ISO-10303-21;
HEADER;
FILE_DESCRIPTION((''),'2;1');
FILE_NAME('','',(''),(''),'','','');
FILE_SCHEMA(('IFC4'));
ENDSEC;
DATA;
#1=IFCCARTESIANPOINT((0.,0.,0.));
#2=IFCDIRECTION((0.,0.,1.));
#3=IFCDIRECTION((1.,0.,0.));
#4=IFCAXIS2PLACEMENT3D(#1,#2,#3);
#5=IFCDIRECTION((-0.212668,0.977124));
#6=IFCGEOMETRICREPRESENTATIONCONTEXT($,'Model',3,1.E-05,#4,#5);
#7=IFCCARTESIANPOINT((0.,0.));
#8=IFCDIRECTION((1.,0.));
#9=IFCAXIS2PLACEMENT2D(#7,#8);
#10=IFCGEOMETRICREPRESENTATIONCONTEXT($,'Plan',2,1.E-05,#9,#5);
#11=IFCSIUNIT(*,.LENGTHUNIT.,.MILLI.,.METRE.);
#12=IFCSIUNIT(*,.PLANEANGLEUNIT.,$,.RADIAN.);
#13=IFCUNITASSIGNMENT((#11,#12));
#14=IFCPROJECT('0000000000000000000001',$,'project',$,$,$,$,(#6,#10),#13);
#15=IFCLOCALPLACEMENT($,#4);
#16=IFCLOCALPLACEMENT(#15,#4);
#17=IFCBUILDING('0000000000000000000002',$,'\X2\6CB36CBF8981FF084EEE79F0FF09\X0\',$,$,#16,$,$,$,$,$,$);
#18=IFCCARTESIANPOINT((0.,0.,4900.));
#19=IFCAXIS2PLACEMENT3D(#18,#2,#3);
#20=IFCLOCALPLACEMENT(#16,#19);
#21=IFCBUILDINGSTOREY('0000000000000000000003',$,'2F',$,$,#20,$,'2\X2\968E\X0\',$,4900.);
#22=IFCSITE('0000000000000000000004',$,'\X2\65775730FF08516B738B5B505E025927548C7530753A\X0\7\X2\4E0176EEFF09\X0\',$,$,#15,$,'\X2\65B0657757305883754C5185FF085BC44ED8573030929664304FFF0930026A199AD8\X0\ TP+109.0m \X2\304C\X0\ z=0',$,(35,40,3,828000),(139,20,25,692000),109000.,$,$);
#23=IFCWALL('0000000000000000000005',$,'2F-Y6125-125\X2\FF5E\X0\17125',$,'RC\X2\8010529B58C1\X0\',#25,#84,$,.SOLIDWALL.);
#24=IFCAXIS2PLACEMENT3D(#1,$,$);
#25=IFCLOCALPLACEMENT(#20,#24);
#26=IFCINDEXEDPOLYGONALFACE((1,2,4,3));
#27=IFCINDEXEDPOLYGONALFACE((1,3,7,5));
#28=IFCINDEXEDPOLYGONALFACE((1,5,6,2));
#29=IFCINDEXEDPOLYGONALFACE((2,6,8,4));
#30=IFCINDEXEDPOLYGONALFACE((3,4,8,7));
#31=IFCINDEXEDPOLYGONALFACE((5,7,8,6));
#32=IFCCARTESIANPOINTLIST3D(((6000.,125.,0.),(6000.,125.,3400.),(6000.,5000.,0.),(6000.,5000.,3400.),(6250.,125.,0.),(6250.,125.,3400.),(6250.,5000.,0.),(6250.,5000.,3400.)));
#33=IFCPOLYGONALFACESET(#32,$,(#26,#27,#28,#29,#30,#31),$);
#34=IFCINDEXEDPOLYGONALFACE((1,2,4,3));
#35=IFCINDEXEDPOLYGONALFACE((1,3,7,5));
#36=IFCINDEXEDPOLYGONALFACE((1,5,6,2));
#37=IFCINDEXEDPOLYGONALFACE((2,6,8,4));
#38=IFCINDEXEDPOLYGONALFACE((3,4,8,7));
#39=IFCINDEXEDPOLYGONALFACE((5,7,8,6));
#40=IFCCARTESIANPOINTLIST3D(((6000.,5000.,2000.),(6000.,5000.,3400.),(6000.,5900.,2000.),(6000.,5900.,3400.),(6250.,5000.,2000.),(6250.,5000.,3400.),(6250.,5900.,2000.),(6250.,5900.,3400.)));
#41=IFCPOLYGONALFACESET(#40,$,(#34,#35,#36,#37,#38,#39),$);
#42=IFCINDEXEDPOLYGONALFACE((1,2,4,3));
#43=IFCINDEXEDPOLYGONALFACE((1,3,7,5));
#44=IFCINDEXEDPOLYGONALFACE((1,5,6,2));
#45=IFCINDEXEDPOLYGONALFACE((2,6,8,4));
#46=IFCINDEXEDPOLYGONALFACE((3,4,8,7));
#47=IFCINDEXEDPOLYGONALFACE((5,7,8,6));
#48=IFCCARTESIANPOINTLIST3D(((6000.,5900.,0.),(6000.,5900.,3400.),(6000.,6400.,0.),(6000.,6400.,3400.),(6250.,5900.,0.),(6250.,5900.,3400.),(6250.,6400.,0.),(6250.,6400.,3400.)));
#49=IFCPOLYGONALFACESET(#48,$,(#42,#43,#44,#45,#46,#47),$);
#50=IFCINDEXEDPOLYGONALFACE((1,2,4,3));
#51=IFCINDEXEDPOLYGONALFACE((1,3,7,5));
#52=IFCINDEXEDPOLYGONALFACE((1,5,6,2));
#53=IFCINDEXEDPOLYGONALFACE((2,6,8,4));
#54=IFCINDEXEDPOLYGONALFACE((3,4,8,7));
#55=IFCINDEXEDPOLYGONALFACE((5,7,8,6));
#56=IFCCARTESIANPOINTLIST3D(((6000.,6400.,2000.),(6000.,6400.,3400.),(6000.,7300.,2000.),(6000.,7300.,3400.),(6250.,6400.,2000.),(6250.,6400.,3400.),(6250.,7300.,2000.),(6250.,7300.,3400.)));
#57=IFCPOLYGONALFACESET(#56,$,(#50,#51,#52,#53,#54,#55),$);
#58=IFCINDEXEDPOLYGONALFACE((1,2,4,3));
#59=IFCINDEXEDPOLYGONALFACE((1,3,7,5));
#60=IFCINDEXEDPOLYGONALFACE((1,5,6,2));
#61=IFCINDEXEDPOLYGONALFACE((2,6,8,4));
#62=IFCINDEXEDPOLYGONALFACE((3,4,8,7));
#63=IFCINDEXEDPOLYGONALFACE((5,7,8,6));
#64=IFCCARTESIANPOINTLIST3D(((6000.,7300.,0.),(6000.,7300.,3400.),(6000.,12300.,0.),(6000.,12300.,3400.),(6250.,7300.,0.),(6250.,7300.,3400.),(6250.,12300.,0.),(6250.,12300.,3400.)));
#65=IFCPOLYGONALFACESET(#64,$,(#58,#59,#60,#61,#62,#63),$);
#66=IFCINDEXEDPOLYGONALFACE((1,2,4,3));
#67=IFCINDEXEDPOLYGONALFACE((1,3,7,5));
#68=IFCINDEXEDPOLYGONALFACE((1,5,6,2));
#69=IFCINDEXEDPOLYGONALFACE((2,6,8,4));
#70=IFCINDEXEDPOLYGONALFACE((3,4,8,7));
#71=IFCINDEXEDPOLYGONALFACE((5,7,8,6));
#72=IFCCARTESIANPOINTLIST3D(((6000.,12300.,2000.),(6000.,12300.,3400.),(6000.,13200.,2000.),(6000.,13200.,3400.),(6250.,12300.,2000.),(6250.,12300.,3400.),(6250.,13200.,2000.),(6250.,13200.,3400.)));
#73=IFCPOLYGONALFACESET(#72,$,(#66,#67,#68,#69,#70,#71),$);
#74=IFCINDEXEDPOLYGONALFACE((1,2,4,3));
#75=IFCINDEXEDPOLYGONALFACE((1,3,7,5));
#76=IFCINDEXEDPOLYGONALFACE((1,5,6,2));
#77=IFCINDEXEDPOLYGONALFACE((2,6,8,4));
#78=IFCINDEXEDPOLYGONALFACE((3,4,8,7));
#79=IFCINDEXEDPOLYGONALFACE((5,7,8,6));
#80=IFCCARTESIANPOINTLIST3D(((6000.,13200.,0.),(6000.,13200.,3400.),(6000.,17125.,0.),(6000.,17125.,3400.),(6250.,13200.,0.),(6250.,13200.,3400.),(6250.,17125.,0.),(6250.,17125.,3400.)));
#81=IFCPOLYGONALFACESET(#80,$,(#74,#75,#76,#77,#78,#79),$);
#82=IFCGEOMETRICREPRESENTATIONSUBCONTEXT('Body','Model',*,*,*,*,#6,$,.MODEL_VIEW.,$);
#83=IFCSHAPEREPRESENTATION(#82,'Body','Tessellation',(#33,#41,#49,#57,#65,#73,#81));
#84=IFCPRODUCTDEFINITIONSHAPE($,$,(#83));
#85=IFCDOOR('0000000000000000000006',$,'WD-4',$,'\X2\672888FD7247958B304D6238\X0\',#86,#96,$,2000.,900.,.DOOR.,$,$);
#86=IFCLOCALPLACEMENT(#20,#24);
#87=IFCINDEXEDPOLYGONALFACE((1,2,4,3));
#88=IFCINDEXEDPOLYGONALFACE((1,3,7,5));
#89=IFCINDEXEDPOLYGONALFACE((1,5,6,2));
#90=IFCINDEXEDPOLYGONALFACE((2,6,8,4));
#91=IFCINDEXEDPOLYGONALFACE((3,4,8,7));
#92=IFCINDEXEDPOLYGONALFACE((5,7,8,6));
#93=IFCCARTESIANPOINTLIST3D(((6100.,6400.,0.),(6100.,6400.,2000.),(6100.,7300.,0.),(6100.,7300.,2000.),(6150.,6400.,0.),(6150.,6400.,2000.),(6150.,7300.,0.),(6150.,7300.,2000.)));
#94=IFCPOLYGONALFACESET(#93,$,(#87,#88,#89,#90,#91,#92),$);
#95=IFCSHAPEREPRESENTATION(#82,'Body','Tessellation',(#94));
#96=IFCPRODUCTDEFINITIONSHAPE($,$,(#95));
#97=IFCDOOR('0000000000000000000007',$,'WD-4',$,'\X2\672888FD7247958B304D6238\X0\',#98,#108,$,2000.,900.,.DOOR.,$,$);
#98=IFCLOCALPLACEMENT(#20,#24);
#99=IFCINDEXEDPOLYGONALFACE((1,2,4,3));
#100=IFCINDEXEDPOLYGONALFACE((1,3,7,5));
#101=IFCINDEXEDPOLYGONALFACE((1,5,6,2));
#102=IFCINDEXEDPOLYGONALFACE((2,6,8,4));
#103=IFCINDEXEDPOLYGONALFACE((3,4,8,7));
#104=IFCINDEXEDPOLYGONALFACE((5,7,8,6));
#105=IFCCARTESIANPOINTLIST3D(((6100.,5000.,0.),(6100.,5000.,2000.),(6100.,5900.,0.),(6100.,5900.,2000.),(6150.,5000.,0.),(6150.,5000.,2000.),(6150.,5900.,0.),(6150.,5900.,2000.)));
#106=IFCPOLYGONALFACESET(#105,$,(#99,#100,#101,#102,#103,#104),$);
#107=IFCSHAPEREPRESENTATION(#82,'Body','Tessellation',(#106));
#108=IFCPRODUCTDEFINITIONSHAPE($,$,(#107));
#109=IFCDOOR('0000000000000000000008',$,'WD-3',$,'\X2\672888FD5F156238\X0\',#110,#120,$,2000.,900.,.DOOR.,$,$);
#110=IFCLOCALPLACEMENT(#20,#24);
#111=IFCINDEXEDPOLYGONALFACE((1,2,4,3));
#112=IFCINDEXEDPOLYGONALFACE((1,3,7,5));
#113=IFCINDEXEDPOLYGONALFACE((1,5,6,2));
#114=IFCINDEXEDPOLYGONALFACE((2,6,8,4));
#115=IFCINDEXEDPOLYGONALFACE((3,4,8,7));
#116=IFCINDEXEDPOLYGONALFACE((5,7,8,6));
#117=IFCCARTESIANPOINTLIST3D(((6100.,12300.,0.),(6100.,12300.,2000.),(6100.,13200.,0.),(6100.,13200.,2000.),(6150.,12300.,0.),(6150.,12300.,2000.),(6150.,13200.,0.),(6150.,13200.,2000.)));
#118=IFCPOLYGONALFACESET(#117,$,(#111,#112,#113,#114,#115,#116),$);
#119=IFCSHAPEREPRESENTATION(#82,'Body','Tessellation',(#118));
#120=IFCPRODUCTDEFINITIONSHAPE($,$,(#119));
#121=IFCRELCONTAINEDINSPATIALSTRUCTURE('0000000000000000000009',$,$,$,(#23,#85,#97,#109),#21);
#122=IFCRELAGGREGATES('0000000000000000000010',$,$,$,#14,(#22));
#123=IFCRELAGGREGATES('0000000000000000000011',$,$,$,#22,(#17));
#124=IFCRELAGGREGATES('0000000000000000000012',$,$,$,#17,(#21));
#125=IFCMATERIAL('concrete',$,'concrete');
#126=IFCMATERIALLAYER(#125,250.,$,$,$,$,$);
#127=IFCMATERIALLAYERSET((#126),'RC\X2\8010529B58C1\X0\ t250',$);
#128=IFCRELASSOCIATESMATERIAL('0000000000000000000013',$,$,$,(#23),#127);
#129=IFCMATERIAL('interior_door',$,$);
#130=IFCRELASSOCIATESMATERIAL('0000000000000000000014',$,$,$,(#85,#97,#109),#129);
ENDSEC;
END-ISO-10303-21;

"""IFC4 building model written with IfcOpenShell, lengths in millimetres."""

from ifc_helpers import new_model, si_unit, direction, frame, frame_2d, origin, origin_with_axes, origin_2d_with_axis, place, context, subcontext, project, spatial, rectangle, extrude, material, layer, layer_set, layer_usage, element, fill, save


model = new_model("IFC4")

# Units and contexts
model_context = context("Model", 3, precision=1e-05, world=origin_with_axes(), true_north=direction((-0.212668, 0.977124)))
plan_context = context("Plan", 2, precision=1e-05, world=origin_2d_with_axis(), true_north=direction((-0.212668, 0.977124)))
body_context = subcontext(model_context, "Body", "Model", "MODEL_VIEW")
ifc_project = project(units=[si_unit("LENGTHUNIT", "METRE", prefix="MILLI"), si_unit("PLANEANGLEUNIT", "RADIAN")], contexts=[model_context, plan_context])

# Site, building, storey
site_placement = place(None, origin_with_axes())
site = spatial("IfcSite", under=ifc_project, at=site_placement, Name="敷地（八王子市大和田町7丁目）", LongName="新敷地境界内（寄付地を除く）。標高 TP+109.0m が z=0", RefLatitude=(35, 40, 3, 828000), RefLongitude=(139, 20, 25, 692000), RefElevation=109000.0)
building_placement = place(site_placement, origin_with_axes())
building = spatial("IfcBuilding", under=site, at=building_placement, Name="河沿要（仮称）")
storey_placement = place(building_placement, frame((0.0, 0.0, 4900.0), z_axis=(0.0, 0.0, 1.0), x_axis=(1.0, 0.0, 0.0)))
storey = spatial("IfcBuildingStorey", under=building, at=storey_placement, Name="2F", LongName="2階", Elevation=4900.0)

# Shared definitions
ifc_material_1 = material(Name="concrete", Category="concrete")

# Wall, openings, doors
ifc_layer_1 = layer(ifc_material_1, 250.0)
ifc_layer_set_1 = layer_set([ifc_layer_1], Name="RC耐力壁 t250")
ifc_layer_usage_1 = layer_usage(ifc_layer_set_1, "AXIS2", "POSITIVE", 0.0)
wall_1_placement = place(storey_placement, origin_with_axes())
wall_1 = element("IfcWall", 1, at=wall_1_placement, inside=storey, material=ifc_layer_usage_1, Name="2F-Y6125-125～17125", ObjectType="RC耐力壁", PredefinedType="SOLIDWALL", context=body_context, shape_type="SweptSolid", body=[
    extrude(rectangle(XDim=250.0, YDim=4875.0, at=frame_2d((6125.0, 2562.5))), origin(), (0.0, 0.0, 1.0), 3400.0),
    extrude(rectangle(XDim=250.0, YDim=900.0, at=frame_2d((6125.0, 5450.0))), frame((0.0, 0.0, 2000.0)), (0.0, 0.0, 1.0), 1400.0),
    extrude(rectangle(XDim=250.0, YDim=500.0, at=frame_2d((6125.0, 6150.0))), origin(), (0.0, 0.0, 1.0), 3400.0),
    extrude(rectangle(XDim=250.0, YDim=900.0, at=frame_2d((6125.0, 6850.0))), frame((0.0, 0.0, 2000.0)), (0.0, 0.0, 1.0), 1400.0),
    extrude(rectangle(XDim=250.0, YDim=5000.0, at=frame_2d((6125.0, 9800.0))), origin(), (0.0, 0.0, 1.0), 3400.0),
    extrude(rectangle(XDim=250.0, YDim=900.0, at=frame_2d((6125.0, 12750.0))), frame((0.0, 0.0, 2000.0)), (0.0, 0.0, 1.0), 1400.0),
    extrude(rectangle(XDim=250.0, YDim=3925.0, at=frame_2d((6125.0, 15162.5))), origin(), (0.0, 0.0, 1.0), 3400.0),
])
opening_1_placement = place(storey_placement, origin_with_axes())
opening_1 = element("IfcOpeningElement", 2, at=opening_1_placement, inside=storey, cuts=wall_1, PredefinedType="OPENING", context=body_context, shape_type="SweptSolid", body=[
    extrude(rectangle(XDim=300.0, YDim=900.0, at=frame_2d((6125.0, 6850.0))), origin(), (0.0, 0.0, 1.0), 2000.0),
])
opening_2_placement = place(storey_placement, origin_with_axes())
opening_2 = element("IfcOpeningElement", 3, at=opening_2_placement, inside=storey, cuts=wall_1, PredefinedType="OPENING", context=body_context, shape_type="SweptSolid", body=[
    extrude(rectangle(XDim=300.0, YDim=900.0, at=frame_2d((6125.0, 5450.0))), origin(), (0.0, 0.0, 1.0), 2000.0),
])
opening_3_placement = place(storey_placement, origin_with_axes())
opening_3 = element("IfcOpeningElement", 4, at=opening_3_placement, inside=storey, cuts=wall_1, PredefinedType="OPENING", context=body_context, shape_type="SweptSolid", body=[
    extrude(rectangle(XDim=300.0, YDim=900.0, at=frame_2d((6125.0, 12750.0))), origin(), (0.0, 0.0, 1.0), 2000.0),
])
ifc_material_2 = material(Name="interior_door")
door_1_placement = place(storey_placement, origin_with_axes())
door_1 = element("IfcDoor", 5, at=door_1_placement, inside=storey, material=ifc_material_2, Name="WD-4", ObjectType="木製片開き戸", OverallHeight=2000.0, OverallWidth=900.0, PredefinedType="DOOR", context=body_context, shape_type="SweptSolid", body=[
    extrude(rectangle(XDim=50.0, YDim=900.0, at=frame_2d((6125.0, 6850.0))), origin(), (0.0, 0.0, 1.0), 2000.0),
])
fill(opening_1, door_1)
door_2_placement = place(storey_placement, origin_with_axes())
door_2 = element("IfcDoor", 6, at=door_2_placement, inside=storey, material=ifc_material_2, Name="WD-4", ObjectType="木製片開き戸", OverallHeight=2000.0, OverallWidth=900.0, PredefinedType="DOOR", context=body_context, shape_type="SweptSolid", body=[
    extrude(rectangle(XDim=50.0, YDim=900.0, at=frame_2d((6125.0, 5450.0))), origin(), (0.0, 0.0, 1.0), 2000.0),
])
fill(opening_2, door_2)
door_3_placement = place(storey_placement, origin_with_axes())
door_3 = element("IfcDoor", 7, at=door_3_placement, inside=storey, material=ifc_material_2, Name="WD-3", ObjectType="木製引戸", OverallHeight=2000.0, OverallWidth=900.0, PredefinedType="DOOR", context=body_context, shape_type="SweptSolid", body=[
    extrude(rectangle(XDim=50.0, YDim=900.0, at=frame_2d((6125.0, 12750.0))), origin(), (0.0, 0.0, 1.0), 2000.0),
])
fill(opening_3, door_3)

save(model, "model.ifc")
